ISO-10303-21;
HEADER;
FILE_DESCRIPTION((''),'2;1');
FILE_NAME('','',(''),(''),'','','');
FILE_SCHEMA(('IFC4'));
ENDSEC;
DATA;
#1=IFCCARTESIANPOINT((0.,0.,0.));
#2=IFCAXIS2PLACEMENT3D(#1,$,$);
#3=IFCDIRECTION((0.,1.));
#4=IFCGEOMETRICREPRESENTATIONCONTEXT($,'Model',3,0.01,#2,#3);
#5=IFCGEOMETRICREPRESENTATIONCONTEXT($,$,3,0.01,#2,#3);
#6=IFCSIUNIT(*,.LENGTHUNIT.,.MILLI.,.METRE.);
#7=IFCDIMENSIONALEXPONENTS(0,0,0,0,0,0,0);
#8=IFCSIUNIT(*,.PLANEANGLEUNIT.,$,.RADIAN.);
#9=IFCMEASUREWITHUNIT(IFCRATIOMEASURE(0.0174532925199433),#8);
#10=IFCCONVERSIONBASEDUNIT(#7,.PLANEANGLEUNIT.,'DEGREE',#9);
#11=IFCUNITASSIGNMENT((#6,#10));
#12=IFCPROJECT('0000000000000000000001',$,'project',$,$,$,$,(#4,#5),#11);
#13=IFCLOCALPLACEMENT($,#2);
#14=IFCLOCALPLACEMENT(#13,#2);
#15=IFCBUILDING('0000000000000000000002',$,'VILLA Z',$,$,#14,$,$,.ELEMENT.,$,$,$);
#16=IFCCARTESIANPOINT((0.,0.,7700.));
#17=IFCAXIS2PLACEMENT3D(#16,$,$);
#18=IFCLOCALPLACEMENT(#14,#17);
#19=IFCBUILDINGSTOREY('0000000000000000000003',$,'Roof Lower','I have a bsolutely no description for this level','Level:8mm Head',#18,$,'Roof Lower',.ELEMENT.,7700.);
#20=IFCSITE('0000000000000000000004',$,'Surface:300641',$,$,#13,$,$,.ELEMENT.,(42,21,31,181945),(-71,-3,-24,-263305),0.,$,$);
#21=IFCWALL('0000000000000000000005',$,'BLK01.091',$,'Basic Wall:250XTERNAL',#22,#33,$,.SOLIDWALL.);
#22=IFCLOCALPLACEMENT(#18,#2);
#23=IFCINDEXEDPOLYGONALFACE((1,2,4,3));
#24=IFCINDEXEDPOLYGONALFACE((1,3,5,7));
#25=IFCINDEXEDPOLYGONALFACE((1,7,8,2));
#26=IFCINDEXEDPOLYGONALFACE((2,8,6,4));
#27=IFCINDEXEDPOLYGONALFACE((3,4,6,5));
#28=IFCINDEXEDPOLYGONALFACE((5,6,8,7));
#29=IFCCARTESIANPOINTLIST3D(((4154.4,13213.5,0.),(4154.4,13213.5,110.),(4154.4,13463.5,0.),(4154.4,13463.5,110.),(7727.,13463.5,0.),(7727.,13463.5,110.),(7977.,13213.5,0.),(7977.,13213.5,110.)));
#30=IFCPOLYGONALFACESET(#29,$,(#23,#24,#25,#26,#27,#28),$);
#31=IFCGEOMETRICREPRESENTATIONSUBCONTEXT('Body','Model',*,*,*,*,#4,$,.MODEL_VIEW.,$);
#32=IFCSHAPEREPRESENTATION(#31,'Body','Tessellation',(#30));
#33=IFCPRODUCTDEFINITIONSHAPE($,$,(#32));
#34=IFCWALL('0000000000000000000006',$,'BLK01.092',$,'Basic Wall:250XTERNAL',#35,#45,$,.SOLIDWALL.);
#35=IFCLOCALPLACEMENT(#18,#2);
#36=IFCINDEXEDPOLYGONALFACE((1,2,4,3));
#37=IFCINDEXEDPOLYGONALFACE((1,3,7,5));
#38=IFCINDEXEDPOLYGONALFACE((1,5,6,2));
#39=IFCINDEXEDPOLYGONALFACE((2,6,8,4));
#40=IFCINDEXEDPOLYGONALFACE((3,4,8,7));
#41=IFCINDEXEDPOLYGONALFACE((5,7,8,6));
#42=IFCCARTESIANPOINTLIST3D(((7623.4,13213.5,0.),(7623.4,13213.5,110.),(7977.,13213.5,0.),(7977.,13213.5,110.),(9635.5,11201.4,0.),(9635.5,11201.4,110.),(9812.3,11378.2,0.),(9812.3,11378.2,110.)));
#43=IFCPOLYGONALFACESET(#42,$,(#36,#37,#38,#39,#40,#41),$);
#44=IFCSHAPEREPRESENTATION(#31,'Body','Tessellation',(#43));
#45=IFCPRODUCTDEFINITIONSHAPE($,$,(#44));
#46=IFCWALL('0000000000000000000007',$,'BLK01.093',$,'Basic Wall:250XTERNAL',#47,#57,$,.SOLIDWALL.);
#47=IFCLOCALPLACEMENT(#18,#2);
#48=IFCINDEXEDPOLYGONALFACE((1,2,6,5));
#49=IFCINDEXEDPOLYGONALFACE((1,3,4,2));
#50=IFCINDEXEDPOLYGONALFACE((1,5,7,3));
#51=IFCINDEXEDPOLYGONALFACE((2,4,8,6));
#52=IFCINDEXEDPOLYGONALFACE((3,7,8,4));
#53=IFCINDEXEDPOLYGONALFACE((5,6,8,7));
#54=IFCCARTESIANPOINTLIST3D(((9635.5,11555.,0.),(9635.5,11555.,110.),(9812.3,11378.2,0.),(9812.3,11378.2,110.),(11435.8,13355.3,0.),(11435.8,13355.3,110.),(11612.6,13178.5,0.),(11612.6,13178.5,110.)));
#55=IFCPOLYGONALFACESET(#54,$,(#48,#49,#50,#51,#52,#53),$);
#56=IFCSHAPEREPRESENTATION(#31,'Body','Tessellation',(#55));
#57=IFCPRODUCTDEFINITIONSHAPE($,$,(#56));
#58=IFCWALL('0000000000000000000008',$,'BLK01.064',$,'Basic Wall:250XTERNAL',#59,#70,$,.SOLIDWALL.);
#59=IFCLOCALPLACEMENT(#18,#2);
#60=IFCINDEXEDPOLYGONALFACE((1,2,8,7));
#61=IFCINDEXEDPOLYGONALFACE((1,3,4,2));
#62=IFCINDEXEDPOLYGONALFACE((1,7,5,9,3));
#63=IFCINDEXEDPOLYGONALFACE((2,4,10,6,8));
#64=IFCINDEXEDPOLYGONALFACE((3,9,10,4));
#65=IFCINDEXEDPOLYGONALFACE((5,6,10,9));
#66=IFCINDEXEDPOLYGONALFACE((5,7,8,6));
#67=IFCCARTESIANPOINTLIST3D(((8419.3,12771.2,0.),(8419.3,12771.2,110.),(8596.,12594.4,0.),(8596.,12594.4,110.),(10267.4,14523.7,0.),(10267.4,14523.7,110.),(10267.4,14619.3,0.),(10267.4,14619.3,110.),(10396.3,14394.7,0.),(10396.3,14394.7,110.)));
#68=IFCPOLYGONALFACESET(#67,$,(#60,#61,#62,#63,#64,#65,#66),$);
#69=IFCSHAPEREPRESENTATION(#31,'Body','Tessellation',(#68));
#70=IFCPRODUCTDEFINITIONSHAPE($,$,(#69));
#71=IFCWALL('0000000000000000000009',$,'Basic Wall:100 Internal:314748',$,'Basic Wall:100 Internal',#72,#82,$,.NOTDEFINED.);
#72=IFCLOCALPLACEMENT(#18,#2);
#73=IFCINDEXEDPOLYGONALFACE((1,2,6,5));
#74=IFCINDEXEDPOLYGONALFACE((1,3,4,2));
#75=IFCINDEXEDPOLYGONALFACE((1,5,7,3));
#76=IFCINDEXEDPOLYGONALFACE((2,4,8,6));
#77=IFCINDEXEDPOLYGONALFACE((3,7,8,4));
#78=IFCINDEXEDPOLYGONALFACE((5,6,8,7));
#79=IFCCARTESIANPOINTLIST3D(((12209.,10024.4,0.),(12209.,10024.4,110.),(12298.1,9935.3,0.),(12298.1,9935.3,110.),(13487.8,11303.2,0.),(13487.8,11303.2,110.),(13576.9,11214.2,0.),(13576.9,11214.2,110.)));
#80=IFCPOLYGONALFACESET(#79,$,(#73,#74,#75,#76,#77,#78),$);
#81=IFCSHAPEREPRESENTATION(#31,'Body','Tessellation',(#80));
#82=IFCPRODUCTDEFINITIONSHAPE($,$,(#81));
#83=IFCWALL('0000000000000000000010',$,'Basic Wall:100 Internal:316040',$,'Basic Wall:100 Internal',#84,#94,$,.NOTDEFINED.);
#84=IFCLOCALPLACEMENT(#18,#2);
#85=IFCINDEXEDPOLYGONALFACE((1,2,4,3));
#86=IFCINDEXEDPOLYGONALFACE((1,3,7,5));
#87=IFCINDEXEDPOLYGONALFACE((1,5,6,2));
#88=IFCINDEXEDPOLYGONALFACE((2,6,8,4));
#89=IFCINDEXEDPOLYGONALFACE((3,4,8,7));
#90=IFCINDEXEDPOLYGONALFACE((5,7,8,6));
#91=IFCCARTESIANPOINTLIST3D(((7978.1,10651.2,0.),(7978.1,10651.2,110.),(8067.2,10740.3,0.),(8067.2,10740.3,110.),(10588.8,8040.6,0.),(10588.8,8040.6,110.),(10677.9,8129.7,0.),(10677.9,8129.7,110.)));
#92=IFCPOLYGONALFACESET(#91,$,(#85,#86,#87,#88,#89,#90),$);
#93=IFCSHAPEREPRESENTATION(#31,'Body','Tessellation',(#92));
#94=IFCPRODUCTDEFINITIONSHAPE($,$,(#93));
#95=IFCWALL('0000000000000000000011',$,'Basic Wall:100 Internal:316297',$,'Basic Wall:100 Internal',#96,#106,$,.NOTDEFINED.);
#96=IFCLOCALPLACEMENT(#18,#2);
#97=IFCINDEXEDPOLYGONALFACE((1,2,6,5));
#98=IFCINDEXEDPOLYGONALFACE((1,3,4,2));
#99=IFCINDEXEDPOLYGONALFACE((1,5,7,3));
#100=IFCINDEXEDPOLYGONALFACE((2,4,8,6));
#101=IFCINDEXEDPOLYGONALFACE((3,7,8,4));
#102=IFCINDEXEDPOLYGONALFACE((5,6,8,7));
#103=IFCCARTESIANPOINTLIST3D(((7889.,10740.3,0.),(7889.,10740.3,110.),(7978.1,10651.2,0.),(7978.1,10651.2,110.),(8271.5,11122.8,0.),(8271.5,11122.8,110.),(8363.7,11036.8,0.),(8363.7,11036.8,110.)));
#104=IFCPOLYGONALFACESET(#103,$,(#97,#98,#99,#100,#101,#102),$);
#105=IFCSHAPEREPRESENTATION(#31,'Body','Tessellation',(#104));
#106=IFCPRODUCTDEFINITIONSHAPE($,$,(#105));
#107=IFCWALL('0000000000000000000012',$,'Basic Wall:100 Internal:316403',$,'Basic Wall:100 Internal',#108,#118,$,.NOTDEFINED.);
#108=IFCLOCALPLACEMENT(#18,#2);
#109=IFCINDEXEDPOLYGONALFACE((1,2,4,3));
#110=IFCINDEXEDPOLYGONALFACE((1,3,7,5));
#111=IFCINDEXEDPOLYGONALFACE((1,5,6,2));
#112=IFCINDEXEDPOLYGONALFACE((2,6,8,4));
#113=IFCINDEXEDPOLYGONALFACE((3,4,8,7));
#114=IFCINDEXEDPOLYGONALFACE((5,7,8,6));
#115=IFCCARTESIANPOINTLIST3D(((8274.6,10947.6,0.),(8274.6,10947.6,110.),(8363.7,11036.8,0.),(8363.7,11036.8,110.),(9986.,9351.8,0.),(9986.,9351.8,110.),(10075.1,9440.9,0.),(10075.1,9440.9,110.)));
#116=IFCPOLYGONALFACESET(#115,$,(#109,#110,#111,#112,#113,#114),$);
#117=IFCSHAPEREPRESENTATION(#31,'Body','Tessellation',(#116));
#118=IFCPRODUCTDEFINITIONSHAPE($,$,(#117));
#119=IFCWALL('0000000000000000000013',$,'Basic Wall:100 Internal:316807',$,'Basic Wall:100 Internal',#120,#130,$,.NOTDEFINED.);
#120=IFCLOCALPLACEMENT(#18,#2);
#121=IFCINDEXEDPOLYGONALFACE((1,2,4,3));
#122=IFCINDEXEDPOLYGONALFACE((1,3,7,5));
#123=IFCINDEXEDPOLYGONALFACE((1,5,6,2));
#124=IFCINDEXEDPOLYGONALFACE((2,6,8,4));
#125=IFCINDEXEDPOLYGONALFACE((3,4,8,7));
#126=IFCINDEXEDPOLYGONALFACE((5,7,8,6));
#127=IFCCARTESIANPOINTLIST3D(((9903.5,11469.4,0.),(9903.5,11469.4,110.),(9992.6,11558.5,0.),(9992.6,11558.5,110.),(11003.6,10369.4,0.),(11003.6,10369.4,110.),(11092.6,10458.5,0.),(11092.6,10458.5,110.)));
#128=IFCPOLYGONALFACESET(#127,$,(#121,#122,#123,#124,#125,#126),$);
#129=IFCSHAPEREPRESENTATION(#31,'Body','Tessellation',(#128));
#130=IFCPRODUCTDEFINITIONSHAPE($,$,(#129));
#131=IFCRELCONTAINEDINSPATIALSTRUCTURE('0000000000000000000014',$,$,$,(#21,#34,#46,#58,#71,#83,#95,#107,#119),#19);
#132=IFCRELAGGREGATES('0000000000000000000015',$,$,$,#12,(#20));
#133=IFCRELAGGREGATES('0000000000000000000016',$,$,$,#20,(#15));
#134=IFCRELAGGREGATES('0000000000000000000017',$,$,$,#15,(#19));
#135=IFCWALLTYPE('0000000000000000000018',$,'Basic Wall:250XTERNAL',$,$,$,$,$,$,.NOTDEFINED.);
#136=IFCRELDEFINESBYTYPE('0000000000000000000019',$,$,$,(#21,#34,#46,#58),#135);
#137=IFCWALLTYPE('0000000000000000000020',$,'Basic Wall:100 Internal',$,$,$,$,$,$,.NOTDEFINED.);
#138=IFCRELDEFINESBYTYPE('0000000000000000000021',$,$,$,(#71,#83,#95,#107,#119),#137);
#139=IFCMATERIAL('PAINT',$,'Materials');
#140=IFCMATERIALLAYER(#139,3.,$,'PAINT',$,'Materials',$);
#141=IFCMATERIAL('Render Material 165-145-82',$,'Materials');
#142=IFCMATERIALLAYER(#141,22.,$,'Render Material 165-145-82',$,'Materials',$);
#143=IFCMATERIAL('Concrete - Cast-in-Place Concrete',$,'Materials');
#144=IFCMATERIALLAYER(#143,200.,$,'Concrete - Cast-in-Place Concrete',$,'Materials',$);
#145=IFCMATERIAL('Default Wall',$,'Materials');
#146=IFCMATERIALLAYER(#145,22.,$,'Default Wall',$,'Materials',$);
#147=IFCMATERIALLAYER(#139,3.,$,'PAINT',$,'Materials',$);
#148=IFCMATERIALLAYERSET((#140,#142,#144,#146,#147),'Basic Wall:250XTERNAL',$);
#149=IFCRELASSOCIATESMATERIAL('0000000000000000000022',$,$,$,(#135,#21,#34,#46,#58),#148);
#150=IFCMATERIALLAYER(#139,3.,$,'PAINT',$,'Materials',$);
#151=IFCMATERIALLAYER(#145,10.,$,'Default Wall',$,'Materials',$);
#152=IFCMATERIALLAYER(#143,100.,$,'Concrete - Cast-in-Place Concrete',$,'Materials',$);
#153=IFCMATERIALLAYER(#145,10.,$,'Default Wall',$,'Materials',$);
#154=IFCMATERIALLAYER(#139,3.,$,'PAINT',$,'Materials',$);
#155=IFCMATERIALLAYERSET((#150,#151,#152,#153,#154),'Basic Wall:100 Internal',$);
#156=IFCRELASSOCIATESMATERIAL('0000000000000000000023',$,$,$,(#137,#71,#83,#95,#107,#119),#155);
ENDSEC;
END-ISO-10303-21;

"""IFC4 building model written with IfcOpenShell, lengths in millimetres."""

from ifc_helpers import new_model, entity, si_unit, converted_unit, direction, frame, frame_2d, origin, place, context, subcontext, project, spatial, polyline, rectangle, outline, extrude, clip, halfspace, bounded_halfspace, material, layer, layer_set, layer_usage, type_object, element, save


model = new_model("IFC4")

# Units and contexts
model_context = context("Model", 3, precision=0.01, world=origin(), true_north=direction((0.0, 1.0)))
context_of_model = context(None, 3, precision=0.01, world=origin(), true_north=direction((0.0, 1.0)))
body_context = subcontext(model_context, "Body", "Model", "MODEL_VIEW")
ifc_project = project(units=[si_unit("LENGTHUNIT", "METRE", prefix="MILLI"), converted_unit("PLANEANGLEUNIT", "DEGREE", entity("IfcRatioMeasure", 0.0174532925199433), si_unit("PLANEANGLEUNIT", "RADIAN"), dimensions=[0, 0, 0, 0, 0, 0, 0])], contexts=[model_context, context_of_model])

# Site, building, storey
site_placement = place(None, origin())
site = spatial("IfcSite", under=ifc_project, at=site_placement, Name="Surface:300641", CompositionType="ELEMENT", RefLatitude=(42, 21, 31, 181945), RefLongitude=(-71, -3, -24, -263305), RefElevation=0.0)
building_placement = place(site_placement, origin())
building = spatial("IfcBuilding", under=site, at=building_placement, Name="VILLA Z", CompositionType="ELEMENT")
storey_placement = place(building_placement, frame((0.0, 0.0, 7700.0)))
storey = spatial("IfcBuildingStorey", under=building, at=storey_placement, Name="Roof Lower", Description="I have a bsolutely no description for this level", ObjectType="Level:8mm Head", LongName="Roof Lower", CompositionType="ELEMENT", Elevation=7700.0)

# Shared definitions
ifc_material_1 = material(Name="Concrete - Cast-in-Place Concrete", Category="Materials")

# Walls
ifc_material_2 = material(Name="PAINT", Category="Materials")
ifc_layer_1 = layer(ifc_material_2, 3.0, Name="PAINT", Category="Materials")
ifc_material_3 = material(Name="Render Material 165-145-82", Category="Materials")
ifc_layer_2 = layer(ifc_material_3, 22.0, Name="Render Material 165-145-82", Category="Materials")
ifc_layer_3 = layer(ifc_material_1, 200.0, Name="Concrete - Cast-in-Place Concrete", Category="Materials")
ifc_material_4 = material(Name="Default Wall", Category="Materials")
ifc_layer_4 = layer(ifc_material_4, 22.0, Name="Default Wall", Category="Materials")
ifc_layer_5 = layer(ifc_material_2, 3.0, Name="PAINT", Category="Materials")
ifc_layer_set_1 = layer_set([ifc_layer_1, ifc_layer_2, ifc_layer_3, ifc_layer_4, ifc_layer_5], Name="Basic Wall:250XTERNAL")
ifc_layer_usage_1 = layer_usage(ifc_layer_set_1, "AXIS2", "NEGATIVE", 125.0)
wall_type_1 = type_object("IfcWallType", Name="Basic Wall:250XTERNAL", PredefinedType="NOTDEFINED", material=ifc_layer_set_1)
wall_1_placement = place(storey_placement, frame((4154.4, 13338.5, 0.0)))
element("IfcWall", 1, at=wall_1_placement, inside=storey, type_object=wall_type_1, material=ifc_layer_usage_1, Name="BLK01.091", ObjectType="Basic Wall:250XTERNAL", PredefinedType="SOLIDWALL", context=body_context, shape_type="Clipping", body=[
    clip(clip(extrude(outline(polyline([(0.0, -125.0), (3469.0, -125.0), (3822.5, -125.0), (3572.5, 125.0), (0.0, 125.0), (0.0, -125.0)])), origin(), (0.0, 0.0, 1.0), 110.0), bounded_halfspace(frame((0.0, -125.0, 110.0), z_axis=(0.0, 0.0, -1.0), x_axis=(1.0, 0.0, 0.0)), True, frame((0.0, -125.0, 110.0)), polyline([(0.0, 0.0), (3469.0, 0.0), (3822.5, 0.0), (3572.5, 250.0), (0.0, 250.0), (0.0, 0.0)]))), halfspace(frame((0.0, 0.0, -3500.0)), True)),
])
ifc_layer_usage_2 = layer_usage(ifc_layer_set_1, "AXIS2", "NEGATIVE", 125.0)
wall_2_placement = place(storey_placement, frame((7711.8, 13301.9, 0.0), z_axis=(0.0, 0.0, 1.0), x_axis=(0.707107, -0.707107, 0.0)))
element("IfcWall", 2, at=wall_2_placement, inside=storey, type_object=wall_type_1, material=ifc_layer_usage_2, Name="BLK01.092", ObjectType="Basic Wall:250XTERNAL", PredefinedType="SOLIDWALL", context=body_context, shape_type="Clipping", body=[
    clip(clip(extrude(outline(polyline([(2845.5, -125.0), (2845.5, 0.0), (2845.5, 125.0), (2595.5, 125.0), (1125.5, 125.0), (875.5, 125.0), (250.0, 125.0), (0.0, -125.0), (2845.5, -125.0)])), origin(), (0.0, 0.0, 1.0), 110.0), bounded_halfspace(frame((0.0, -125.0, 110.0), z_axis=(0.0, 0.0, -1.0), x_axis=(0.707107, 0.707107, 0.0)), True, frame((0.0, -125.0, 110.0)), polyline([(0.0, 0.0), (2845.5, 0.0), (2845.5, 125.0), (2845.5, 250.0), (2595.5, 250.0), (1125.5, 250.0), (875.5, 250.0), (250.0, 250.0), (0.0, 0.0)]))), halfspace(frame((0.0, 0.0, -3500.0)), True)),
])
ifc_layer_usage_3 = layer_usage(ifc_layer_set_1, "AXIS2", "NEGATIVE", 125.0)
wall_3_placement = place(storey_placement, frame((9723.9, 11466.6, 0.0), z_axis=(0.0, 0.0, 1.0), x_axis=(0.707107, 0.707107, 0.0)))
element("IfcWall", 3, at=wall_3_placement, inside=storey, type_object=wall_type_1, material=ifc_layer_usage_3, Name="BLK01.093", ObjectType="Basic Wall:250XTERNAL", PredefinedType="SOLIDWALL", context=body_context, shape_type="Clipping", body=[
    clip(clip(extrude(rectangle(XDim=2546.0, YDim=250.0, at=frame_2d((1273.0, 0.0), x_axis=(-1.0, 0.0))), origin(), (0.0, 0.0, 1.0), 110.0), bounded_halfspace(frame((0.0, -125.0, 110.0), z_axis=(0.0, 0.0, -1.0), x_axis=(0.707107, -0.707107, 0.0)), True, frame((0.0, -125.0, 110.0)), polyline([(0.0, 0.0), (129.0, 0.0), (255.0, 0.0), (2546.0, 0.0), (2546.0, 250.0), (0.0, 250.0), (0.0, 0.0)]))), halfspace(frame((0.0, 0.0, -3500.0)), True)),
])
ifc_layer_usage_4 = layer_usage(ifc_layer_set_1, "AXIS2", "POSITIVE", -125.0)
wall_4_placement = place(storey_placement, frame((8507.6, 12682.8, 0.0), z_axis=(0.0, 0.0, 1.0), x_axis=(0.707107, 0.707107, 0.0)))
element("IfcWall", 4, at=wall_4_placement, inside=storey, type_object=wall_type_1, material=ifc_layer_usage_4, Name="BLK01.064", ObjectType="Basic Wall:250XTERNAL", PredefinedType="SOLIDWALL", context=body_context, shape_type="Clipping", body=[
    clip(clip(extrude(outline(polyline([(2546.0, -125.0), (2546.0, 57.4), (2613.6, 125.0), (0.0, 125.0), (0.0, -125.0), (2546.0, -125.0)])), origin(), (0.0, 0.0, 1.0), 110.0), bounded_halfspace(frame((0.0, -125.0, 110.0), z_axis=(0.0, 0.0, -1.0), x_axis=(0.707107, -0.707107, 0.0)), True, frame((0.0, -125.0, 110.0)), polyline([(0.0, 0.0), (2546.0, 0.0), (2546.0, 182.4), (2613.6, 250.0), (0.0, 250.0), (0.0, 0.0)]))), halfspace(frame((0.0, 0.0, -3500.0)), True)),
])
ifc_layer_6 = layer(ifc_material_2, 3.0, Name="PAINT", Category="Materials")
ifc_layer_7 = layer(ifc_material_4, 10.0, Name="Default Wall", Category="Materials")
ifc_layer_8 = layer(ifc_material_1, 100.0, Name="Concrete - Cast-in-Place Concrete", Category="Materials")
ifc_layer_9 = layer(ifc_material_4, 10.0, Name="Default Wall", Category="Materials")
ifc_layer_10 = layer(ifc_material_2, 3.0, Name="PAINT", Category="Materials")
ifc_layer_set_2 = layer_set([ifc_layer_6, ifc_layer_7, ifc_layer_8, ifc_layer_9, ifc_layer_10], Name="Basic Wall:100 Internal")
ifc_layer_usage_5 = layer_usage(ifc_layer_set_2, "AXIS2", "NEGATIVE", 63.0)
wall_type_2 = type_object("IfcWallType", Name="Basic Wall:100 Internal", PredefinedType="NOTDEFINED", material=ifc_layer_set_2)
wall_5_placement = place(storey_placement, frame((13532.4, 11258.7, 0.0), z_axis=(0.0, 0.0, 1.0), x_axis=(-0.707107, -0.707107, 0.0)))
element("IfcWall", 5, at=wall_5_placement, inside=storey, type_object=wall_type_2, material=ifc_layer_usage_5, Name="Basic Wall:100 Internal:314748", ObjectType="Basic Wall:100 Internal", PredefinedType="NOTDEFINED", context=body_context, shape_type="Clipping", body=[
    clip(clip(extrude(rectangle(XDim=1808.6, YDim=126.0, at=frame_2d((904.3, 0.0), x_axis=(-1.0, 0.0))), origin(), (0.0, 0.0, 1.0), 110.0), bounded_halfspace(frame((0.0, -63.0, 110.0), z_axis=(0.0, 0.0, -1.0), x_axis=(-0.707107, 0.707107, 0.0)), True, frame((0.0, -63.0, 110.0)), polyline([(0.0, 0.0), (1808.6, 0.0), (1808.6, 126.0), (0.0, 126.0), (0.0, 0.0)]))), halfspace(frame((0.0, 0.0, -3500.0)), True)),
])
ifc_layer_usage_6 = layer_usage(ifc_layer_set_2, "AXIS2", "POSITIVE", -63.0)
wall_6_placement = place(storey_placement, frame((8022.7, 10695.7, 0.0), z_axis=(0.0, 0.0, 1.0), x_axis=(0.707107, -0.707107, 0.0)))
element("IfcWall", 6, at=wall_6_placement, inside=storey, type_object=wall_type_2, material=ifc_layer_usage_6, Name="Basic Wall:100 Internal:316040", ObjectType="Basic Wall:100 Internal", PredefinedType="NOTDEFINED", context=body_context, shape_type="Clipping", body=[
    clip(clip(extrude(rectangle(XDim=3692.0, YDim=126.0, at=frame_2d((1846.0, 0.0), x_axis=(-1.0, 0.0))), origin(), (0.0, 0.0, 1.0), 110.0), bounded_halfspace(frame((0.0, -63.0, 110.0), z_axis=(0.0, 0.0, -1.0), x_axis=(0.707107, 0.707107, 0.0)), True, frame((0.0, -63.0, 110.0)), polyline([(0.0, 0.0), (3692.0, 0.0), (3692.0, 126.0), (2338.6, 126.0), (2212.6, 126.0), (0.0, 126.0), (0.0, 0.0)]))), halfspace(frame((0.0, 0.0, -3500.0)), True)),
])
ifc_layer_usage_7 = layer_usage(ifc_layer_set_2, "AXIS2", "NEGATIVE", 63.0)
wall_7_placement = place(storey_placement, frame((7933.6, 10695.7, 0.0), z_axis=(0.0, 0.0, 1.0), x_axis=(0.707107, 0.707107, 0.0)))
element("IfcWall", 7, at=wall_7_placement, inside=storey, type_object=wall_type_2, material=ifc_layer_usage_7, Name="Basic Wall:100 Internal:316297", ObjectType="Basic Wall:100 Internal", PredefinedType="NOTDEFINED", context=body_context, shape_type="Clipping", body=[
    clip(clip(extrude(outline(polyline([(545.3, -63.0), (540.9, 63.0), (0.0, 63.0), (0.0, -63.0), (126.0, -63.0), (419.2, -63.0), (545.3, -63.0)])), origin(), (0.0, 0.0, 1.0), 110.0), bounded_halfspace(frame((0.0, -63.0, 110.0), z_axis=(0.0, 0.0, -1.0), x_axis=(0.707107, -0.707107, 0.0)), True, frame((0.0, -63.0, 110.0)), polyline([(0.0, 0.0), (126.0, 0.0), (419.2, 0.0), (545.3, 0.0), (540.9, 126.0), (0.0, 126.0), (0.0, 0.0)]))), halfspace(frame((0.0, 0.0, -3500.0)), True)),
])
ifc_layer_usage_8 = layer_usage(ifc_layer_set_2, "AXIS2", "NEGATIVE", 63.0)
wall_8_placement = place(storey_placement, frame((8317.6, 10993.7, 0.0), z_axis=(0.0, 0.0, 1.0), x_axis=(0.731354, -0.681998, 0.0)))
element("IfcWall", 8, at=wall_8_placement, inside=storey, type_object=wall_type_2, material=ifc_layer_usage_8, Name="Basic Wall:100 Internal:316403", ObjectType="Basic Wall:100 Internal", PredefinedType="NOTDEFINED", context=body_context, shape_type="Clipping", body=[
    clip(clip(extrude(outline(polyline([(2340.0, -63.0), (2344.4, 63.0), (2218.3, 63.0), (4.4, 63.0), (0.0, -63.0), (2213.9, -63.0), (2340.0, -63.0)])), origin(), (0.0, 0.0, 1.0), 110.0), bounded_halfspace(frame((0.0, -63.0, 110.0), z_axis=(0.0, 0.0, -1.0), x_axis=(0.731354, 0.681998, 0.0)), True, frame((0.0, -63.0, 110.0)), polyline([(0.0, 0.0), (2213.9, 0.0), (2340.0, 0.0), (2344.4, 126.0), (2218.3, 126.0), (4.4, 126.0), (0.0, 0.0)]))), halfspace(frame((0.0, 0.0, -3500.0)), True)),
])
ifc_layer_usage_9 = layer_usage(ifc_layer_set_2, "AXIS2", "NEGATIVE", 63.0)
wall_9_placement = place(storey_placement, frame((9948.0, 11514.0, 0.0), z_axis=(0.0, 0.0, 1.0), x_axis=(0.707107, -0.707107, 0.0)))
element("IfcWall", 9, at=wall_9_placement, inside=storey, type_object=wall_type_2, material=ifc_layer_usage_9, Name="Basic Wall:100 Internal:316807", ObjectType="Basic Wall:100 Internal", PredefinedType="NOTDEFINED", context=body_context, shape_type="Clipping", body=[
    clip(clip(extrude(rectangle(XDim=1555.7, YDim=126.0, at=frame_2d((777.9, 0.0), x_axis=(-1.0, 0.0))), origin(), (0.0, 0.0, 1.0), 110.0), bounded_halfspace(frame((0.0, -63.0, 110.0), z_axis=(0.0, 0.0, -1.0), x_axis=(0.707107, 0.707107, 0.0)), True, frame((0.0, -63.0, 110.0)), polyline([(0.0, 0.0), (1429.7, 0.0), (1555.7, 0.0), (1555.7, 126.0), (0.0, 126.0), (0.0, 0.0)]))), halfspace(frame((0.0, 0.0, -3500.0)), True)),
])

save(model, "model.ifc")
